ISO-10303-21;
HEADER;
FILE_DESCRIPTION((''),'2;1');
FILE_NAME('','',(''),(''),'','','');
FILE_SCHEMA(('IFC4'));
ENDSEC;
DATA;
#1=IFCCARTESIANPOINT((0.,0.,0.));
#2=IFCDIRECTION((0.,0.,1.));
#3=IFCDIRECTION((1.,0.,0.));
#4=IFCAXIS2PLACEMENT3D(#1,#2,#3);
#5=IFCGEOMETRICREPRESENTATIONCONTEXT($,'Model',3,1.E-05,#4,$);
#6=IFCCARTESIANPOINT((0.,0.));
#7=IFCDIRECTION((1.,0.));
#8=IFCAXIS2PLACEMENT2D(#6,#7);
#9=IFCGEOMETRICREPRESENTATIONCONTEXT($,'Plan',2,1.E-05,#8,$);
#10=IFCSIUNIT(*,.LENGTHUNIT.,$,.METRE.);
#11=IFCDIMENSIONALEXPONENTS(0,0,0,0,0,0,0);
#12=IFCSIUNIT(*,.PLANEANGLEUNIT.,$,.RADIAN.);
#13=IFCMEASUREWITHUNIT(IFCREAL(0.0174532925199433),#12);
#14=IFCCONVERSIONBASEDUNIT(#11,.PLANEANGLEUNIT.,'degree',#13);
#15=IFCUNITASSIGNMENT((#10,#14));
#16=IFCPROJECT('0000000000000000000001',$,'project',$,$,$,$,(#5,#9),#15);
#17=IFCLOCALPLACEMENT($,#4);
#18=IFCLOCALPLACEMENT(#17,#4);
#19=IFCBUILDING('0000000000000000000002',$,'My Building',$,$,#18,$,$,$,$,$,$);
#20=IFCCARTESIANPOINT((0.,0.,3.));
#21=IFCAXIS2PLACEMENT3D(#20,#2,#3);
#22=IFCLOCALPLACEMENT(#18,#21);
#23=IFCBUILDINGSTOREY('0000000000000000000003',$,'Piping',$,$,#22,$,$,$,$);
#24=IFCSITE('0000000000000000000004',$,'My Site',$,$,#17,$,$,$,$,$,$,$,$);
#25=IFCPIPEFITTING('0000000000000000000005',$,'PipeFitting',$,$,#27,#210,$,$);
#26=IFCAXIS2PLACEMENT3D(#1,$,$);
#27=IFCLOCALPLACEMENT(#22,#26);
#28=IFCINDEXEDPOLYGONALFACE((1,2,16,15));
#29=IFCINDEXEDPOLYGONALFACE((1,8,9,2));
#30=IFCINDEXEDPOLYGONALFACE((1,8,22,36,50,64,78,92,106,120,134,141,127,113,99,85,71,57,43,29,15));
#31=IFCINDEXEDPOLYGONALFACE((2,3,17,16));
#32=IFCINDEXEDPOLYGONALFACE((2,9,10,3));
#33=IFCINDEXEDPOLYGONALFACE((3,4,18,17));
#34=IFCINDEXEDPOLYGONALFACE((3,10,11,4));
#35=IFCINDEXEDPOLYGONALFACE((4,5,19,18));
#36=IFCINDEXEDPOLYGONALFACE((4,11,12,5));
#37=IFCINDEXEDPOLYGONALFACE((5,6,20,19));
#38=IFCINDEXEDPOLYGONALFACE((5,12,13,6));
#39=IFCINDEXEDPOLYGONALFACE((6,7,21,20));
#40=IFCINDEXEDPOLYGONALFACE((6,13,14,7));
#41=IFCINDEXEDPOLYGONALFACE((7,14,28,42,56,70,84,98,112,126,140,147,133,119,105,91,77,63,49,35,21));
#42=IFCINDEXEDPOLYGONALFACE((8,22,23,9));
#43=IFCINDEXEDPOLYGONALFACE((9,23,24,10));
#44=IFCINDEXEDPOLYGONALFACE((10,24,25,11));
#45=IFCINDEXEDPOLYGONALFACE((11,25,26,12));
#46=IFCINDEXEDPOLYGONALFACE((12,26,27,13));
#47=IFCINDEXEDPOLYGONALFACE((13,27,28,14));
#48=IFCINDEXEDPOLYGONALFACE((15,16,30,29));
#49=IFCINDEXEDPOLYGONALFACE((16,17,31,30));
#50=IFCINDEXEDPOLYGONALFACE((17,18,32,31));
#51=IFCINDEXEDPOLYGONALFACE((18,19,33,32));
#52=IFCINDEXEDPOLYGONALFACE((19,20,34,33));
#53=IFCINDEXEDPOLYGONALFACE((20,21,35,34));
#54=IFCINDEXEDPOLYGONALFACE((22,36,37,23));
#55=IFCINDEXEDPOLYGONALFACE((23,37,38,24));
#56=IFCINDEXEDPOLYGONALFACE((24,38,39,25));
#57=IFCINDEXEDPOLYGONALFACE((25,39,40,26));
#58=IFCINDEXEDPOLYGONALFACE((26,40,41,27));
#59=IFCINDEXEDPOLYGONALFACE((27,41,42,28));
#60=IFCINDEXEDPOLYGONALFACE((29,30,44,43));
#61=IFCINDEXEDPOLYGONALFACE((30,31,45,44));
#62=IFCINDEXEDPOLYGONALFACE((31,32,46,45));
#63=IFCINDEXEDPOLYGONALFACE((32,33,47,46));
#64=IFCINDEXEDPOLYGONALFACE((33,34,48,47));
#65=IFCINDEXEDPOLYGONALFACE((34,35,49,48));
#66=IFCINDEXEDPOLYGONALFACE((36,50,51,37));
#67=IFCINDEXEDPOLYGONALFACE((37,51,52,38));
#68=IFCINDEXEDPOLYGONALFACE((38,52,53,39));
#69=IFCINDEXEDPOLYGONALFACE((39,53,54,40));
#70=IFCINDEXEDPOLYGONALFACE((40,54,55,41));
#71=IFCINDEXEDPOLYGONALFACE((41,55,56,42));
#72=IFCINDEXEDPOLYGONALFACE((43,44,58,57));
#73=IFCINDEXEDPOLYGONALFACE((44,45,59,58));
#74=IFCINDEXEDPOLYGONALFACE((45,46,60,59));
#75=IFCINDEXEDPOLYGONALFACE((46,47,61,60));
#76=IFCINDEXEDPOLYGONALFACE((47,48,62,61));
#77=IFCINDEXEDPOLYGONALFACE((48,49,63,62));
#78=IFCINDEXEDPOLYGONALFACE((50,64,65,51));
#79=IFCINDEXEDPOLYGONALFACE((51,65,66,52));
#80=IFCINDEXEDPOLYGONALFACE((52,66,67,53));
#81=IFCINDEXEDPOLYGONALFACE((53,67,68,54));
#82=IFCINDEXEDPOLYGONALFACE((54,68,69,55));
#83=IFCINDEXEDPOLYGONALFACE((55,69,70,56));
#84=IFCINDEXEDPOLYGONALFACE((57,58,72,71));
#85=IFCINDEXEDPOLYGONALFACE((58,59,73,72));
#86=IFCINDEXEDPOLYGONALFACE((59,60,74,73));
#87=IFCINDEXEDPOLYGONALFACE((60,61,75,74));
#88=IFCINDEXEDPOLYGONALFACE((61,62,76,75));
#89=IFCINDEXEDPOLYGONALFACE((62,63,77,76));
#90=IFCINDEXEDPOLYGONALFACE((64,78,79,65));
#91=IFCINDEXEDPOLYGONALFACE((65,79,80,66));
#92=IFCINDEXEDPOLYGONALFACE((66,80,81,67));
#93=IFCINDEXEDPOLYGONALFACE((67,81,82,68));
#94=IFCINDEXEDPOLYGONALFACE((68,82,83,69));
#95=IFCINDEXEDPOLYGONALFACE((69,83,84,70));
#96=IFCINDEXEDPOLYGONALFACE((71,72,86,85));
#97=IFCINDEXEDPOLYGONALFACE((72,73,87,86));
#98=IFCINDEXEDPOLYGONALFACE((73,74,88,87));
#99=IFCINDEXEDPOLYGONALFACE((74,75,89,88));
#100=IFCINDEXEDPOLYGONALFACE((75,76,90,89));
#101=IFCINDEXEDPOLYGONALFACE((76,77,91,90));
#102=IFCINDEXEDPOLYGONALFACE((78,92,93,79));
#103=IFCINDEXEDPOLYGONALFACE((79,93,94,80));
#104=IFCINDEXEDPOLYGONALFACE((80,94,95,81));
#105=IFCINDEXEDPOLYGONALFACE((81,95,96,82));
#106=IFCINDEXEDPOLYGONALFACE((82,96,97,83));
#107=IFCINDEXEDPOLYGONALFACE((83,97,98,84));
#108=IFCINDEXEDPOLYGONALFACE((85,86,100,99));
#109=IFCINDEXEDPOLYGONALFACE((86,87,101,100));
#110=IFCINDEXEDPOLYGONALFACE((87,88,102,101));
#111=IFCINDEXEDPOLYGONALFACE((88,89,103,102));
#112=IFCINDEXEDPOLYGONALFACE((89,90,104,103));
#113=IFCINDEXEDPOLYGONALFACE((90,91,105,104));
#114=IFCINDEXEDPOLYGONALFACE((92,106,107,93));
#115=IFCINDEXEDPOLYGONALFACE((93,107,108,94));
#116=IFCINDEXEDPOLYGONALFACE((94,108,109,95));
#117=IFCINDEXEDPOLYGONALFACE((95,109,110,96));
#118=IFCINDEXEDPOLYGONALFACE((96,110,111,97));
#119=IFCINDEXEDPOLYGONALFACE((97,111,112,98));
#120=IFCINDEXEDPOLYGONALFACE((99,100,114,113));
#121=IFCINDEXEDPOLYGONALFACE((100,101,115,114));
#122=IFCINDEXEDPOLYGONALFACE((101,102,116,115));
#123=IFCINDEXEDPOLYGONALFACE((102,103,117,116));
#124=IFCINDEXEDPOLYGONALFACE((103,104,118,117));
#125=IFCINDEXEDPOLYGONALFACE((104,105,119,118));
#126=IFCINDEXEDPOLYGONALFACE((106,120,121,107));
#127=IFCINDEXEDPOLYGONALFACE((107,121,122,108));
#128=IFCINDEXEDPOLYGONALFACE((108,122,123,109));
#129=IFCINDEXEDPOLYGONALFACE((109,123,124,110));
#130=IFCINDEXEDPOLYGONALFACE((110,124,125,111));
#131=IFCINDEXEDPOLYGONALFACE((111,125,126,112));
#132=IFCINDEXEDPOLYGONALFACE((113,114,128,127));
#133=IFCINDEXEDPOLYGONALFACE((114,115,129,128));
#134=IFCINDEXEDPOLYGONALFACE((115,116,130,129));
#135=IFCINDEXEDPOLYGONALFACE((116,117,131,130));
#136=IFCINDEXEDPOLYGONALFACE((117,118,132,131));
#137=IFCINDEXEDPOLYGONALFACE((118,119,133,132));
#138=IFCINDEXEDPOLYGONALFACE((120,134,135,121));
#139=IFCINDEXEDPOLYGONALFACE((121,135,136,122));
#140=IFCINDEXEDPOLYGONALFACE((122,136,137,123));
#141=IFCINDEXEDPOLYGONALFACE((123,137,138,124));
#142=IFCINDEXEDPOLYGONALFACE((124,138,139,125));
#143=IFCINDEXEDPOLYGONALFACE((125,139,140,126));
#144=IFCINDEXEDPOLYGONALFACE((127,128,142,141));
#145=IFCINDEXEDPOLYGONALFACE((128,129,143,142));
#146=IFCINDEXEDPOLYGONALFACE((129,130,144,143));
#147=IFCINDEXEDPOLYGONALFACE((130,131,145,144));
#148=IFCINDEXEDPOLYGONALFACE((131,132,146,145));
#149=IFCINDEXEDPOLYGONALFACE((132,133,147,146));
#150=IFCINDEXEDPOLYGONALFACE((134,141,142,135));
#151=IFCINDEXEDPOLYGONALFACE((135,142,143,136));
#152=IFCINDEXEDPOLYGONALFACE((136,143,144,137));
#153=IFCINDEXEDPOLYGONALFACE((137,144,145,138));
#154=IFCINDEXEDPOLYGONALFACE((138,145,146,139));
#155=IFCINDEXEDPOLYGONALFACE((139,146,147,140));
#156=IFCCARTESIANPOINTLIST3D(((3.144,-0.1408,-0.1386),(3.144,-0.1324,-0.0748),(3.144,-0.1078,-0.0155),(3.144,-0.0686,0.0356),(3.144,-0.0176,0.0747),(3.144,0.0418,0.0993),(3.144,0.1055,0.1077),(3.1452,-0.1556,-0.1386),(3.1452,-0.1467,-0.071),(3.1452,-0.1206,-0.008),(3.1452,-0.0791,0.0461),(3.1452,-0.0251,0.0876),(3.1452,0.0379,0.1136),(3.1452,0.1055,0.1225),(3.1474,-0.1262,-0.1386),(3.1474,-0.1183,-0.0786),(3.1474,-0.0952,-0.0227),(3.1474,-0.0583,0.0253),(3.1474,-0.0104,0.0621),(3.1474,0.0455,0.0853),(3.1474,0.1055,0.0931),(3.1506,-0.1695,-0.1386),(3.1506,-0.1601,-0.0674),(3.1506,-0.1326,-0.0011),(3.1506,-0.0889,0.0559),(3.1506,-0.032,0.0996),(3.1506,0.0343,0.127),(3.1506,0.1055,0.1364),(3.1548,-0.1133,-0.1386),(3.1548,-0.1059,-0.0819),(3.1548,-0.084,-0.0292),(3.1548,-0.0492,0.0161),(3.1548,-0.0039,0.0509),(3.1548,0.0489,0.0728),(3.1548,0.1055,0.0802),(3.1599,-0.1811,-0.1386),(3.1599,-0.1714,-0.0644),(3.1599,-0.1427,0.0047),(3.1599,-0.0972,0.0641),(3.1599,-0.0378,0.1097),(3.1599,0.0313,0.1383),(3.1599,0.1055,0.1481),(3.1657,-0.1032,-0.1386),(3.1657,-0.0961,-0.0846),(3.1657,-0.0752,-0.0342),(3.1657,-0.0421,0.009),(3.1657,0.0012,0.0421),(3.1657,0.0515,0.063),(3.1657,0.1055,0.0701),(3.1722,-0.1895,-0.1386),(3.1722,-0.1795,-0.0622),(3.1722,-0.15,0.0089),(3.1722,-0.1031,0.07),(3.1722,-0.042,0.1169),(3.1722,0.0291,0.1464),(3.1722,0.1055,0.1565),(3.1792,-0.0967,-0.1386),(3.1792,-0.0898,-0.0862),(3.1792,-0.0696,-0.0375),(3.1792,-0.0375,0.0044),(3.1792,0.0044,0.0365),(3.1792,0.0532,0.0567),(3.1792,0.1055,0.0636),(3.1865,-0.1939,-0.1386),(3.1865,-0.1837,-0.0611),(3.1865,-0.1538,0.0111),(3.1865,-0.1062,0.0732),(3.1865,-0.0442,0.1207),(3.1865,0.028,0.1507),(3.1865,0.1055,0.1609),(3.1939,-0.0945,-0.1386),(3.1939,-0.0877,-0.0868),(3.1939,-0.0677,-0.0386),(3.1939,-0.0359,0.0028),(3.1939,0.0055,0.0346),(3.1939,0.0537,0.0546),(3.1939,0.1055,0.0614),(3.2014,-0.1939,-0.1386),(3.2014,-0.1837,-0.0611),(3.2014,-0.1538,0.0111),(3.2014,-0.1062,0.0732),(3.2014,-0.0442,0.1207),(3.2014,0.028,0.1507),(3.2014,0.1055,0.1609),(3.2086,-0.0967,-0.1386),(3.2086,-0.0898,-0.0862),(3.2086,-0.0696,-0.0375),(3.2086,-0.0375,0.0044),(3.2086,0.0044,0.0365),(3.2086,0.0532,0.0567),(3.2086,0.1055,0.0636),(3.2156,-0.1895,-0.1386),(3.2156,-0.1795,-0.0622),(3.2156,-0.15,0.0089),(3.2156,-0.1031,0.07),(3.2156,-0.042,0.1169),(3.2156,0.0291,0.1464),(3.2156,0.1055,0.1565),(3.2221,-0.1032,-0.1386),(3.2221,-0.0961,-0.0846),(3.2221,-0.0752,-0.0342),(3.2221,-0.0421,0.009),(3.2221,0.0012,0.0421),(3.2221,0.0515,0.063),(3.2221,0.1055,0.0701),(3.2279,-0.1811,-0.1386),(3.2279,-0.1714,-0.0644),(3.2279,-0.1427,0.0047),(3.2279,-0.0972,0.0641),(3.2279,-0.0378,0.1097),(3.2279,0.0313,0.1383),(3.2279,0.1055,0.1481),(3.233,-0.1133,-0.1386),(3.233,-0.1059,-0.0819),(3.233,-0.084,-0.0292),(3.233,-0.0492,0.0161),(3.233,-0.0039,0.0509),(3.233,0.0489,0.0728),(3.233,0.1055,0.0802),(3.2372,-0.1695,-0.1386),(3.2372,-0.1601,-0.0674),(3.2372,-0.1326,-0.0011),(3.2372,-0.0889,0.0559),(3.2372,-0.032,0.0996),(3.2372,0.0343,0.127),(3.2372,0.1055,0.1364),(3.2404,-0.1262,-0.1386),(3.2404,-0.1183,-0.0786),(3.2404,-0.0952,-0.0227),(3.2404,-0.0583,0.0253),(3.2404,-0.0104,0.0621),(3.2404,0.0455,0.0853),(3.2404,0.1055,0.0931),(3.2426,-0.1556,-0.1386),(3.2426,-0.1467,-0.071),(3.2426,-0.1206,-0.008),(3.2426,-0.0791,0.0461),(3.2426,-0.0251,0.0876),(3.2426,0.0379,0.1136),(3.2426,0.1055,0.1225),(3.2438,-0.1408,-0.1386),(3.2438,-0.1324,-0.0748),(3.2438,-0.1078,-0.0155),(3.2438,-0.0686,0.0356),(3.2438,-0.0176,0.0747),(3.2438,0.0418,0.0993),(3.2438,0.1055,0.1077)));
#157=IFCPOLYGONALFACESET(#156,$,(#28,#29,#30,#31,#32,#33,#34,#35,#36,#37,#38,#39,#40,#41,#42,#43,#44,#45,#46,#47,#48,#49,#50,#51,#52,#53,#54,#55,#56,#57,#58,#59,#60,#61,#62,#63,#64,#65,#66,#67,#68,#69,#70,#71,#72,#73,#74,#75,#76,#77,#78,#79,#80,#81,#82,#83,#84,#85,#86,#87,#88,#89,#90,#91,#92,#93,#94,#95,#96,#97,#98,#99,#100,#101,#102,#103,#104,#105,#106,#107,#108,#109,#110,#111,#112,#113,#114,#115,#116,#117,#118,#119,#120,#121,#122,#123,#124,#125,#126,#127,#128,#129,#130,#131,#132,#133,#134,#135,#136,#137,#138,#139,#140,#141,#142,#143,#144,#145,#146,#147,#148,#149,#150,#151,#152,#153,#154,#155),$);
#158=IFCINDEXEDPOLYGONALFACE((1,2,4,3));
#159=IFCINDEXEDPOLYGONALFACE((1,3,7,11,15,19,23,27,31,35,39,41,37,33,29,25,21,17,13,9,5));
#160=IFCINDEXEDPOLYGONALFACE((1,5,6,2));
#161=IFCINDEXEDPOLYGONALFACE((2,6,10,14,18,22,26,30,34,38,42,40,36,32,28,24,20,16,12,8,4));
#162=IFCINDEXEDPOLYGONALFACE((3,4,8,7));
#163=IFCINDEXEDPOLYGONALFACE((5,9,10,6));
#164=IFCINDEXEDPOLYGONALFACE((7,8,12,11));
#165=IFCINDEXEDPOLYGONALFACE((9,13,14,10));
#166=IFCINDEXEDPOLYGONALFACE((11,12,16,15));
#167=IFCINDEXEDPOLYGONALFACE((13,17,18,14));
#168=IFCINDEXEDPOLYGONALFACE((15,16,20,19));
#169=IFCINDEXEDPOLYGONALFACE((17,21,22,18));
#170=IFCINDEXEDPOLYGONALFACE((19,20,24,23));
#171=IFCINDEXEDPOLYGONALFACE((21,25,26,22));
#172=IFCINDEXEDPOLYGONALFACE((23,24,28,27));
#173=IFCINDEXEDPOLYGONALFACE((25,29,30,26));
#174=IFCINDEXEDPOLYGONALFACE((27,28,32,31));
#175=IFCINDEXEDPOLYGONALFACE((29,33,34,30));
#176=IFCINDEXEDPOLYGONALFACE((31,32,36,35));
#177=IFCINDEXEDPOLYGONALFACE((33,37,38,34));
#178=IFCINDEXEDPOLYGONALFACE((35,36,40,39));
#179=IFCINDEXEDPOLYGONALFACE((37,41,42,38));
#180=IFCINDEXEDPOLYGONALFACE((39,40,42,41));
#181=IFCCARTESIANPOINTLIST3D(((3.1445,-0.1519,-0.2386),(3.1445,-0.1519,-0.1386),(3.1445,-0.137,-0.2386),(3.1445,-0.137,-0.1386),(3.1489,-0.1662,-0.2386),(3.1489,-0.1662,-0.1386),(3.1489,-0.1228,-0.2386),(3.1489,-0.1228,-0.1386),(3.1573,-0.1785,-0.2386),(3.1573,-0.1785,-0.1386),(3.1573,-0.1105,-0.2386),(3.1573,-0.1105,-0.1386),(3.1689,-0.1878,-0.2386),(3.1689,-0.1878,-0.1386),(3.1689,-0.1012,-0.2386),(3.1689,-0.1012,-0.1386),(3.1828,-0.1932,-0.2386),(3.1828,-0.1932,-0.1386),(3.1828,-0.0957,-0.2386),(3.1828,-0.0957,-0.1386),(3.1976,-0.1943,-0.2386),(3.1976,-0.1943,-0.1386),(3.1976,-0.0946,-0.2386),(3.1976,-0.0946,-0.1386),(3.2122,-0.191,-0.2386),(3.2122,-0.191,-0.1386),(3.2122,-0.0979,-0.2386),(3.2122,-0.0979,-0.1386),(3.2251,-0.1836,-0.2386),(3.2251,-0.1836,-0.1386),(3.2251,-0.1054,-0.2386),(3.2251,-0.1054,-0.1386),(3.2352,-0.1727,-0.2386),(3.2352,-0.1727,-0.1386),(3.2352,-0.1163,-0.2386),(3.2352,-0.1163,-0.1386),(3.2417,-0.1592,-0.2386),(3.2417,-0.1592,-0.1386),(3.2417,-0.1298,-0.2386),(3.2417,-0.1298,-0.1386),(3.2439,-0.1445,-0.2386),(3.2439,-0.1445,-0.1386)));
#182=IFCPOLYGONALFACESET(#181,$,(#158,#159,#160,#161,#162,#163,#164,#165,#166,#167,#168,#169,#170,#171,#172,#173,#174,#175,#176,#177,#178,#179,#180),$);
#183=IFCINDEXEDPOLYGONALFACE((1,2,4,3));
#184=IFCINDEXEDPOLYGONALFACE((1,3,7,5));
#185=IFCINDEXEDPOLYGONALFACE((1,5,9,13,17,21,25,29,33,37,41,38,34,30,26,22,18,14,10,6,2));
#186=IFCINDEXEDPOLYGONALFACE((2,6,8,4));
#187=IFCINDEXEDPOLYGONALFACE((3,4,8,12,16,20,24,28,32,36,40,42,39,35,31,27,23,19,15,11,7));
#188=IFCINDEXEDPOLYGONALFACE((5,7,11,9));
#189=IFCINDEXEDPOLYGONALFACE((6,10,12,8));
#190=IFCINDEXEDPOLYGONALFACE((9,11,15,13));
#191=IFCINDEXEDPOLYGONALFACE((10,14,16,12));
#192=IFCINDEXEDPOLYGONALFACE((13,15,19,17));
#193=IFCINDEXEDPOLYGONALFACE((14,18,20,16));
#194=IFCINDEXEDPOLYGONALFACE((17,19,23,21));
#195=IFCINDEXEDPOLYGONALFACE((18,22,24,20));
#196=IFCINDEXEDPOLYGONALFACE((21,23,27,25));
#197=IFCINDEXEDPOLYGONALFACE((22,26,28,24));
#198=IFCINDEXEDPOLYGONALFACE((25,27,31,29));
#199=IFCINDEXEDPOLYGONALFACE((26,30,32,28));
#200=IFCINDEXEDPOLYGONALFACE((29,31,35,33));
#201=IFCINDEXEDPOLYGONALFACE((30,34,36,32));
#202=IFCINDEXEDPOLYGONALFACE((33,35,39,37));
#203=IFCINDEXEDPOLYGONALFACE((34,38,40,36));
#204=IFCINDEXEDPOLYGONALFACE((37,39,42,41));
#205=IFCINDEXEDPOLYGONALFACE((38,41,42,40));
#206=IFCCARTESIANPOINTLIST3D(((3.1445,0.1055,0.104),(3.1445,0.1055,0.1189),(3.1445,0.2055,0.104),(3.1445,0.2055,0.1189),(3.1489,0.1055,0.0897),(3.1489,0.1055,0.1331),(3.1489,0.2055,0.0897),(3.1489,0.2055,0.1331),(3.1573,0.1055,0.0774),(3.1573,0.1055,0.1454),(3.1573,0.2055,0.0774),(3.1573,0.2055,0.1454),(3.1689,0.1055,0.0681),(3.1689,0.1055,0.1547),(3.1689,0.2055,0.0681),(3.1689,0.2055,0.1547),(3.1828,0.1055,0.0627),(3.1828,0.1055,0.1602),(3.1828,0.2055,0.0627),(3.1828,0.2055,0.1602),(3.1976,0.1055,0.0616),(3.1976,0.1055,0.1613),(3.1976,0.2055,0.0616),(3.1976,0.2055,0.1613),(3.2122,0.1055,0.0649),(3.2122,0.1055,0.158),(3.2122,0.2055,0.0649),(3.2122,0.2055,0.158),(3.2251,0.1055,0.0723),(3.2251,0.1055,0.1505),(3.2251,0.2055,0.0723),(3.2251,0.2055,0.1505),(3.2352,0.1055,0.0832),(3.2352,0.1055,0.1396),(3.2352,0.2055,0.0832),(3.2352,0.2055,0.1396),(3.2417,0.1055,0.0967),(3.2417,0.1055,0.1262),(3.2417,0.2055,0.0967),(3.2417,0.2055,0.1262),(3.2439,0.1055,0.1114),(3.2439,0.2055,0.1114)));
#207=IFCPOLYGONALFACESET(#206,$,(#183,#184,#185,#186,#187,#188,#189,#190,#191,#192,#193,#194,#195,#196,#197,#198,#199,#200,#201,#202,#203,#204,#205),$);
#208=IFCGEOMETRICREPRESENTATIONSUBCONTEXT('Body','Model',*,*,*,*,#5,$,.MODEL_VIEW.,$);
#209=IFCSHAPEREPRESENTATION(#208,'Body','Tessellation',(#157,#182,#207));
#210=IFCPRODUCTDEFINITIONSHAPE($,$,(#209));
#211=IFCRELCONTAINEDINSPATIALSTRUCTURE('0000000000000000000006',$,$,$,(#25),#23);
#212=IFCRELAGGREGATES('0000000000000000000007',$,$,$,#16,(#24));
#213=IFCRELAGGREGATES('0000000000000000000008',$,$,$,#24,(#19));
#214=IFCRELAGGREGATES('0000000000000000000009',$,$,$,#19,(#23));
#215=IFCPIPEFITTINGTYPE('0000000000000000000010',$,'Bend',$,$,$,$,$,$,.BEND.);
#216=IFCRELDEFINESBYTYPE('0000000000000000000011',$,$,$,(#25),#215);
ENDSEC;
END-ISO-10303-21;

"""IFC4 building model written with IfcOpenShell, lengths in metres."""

from ifc_helpers import new_model, entity, si_unit, converted_unit, frame, origin_with_axes, origin_2d_with_axis, place, context, subcontext, project, spatial, circle, extrude, source, transform, mapped, type_object, type_shapes, element, save


model = new_model("IFC4")

# Units and contexts
model_context = context("Model", 3, precision=1e-05, world=origin_with_axes())
plan_context = context("Plan", 2, precision=1e-05, world=origin_2d_with_axis())
body_context = subcontext(model_context, "Body", "Model", "MODEL_VIEW")
ifc_project = project(units=[si_unit("LENGTHUNIT", "METRE"), converted_unit("PLANEANGLEUNIT", "degree", entity("IfcReal", 0.0174532925199433), si_unit("PLANEANGLEUNIT", "RADIAN"), dimensions=[0, 0, 0, 0, 0, 0, 0])], contexts=[model_context, plan_context])

# Site, building, storey
site_placement = place(None, origin_with_axes())
site = spatial("IfcSite", under=ifc_project, at=site_placement, Name="My Site")
building_placement = place(site_placement, origin_with_axes())
building = spatial("IfcBuilding", under=site, at=building_placement, Name="My Building")
storey_placement = place(building_placement, frame((0.0, 0.0, 3.0), z_axis=(0.0, 0.0, 1.0), x_axis=(1.0, 0.0, 0.0)))
storey = spatial("IfcBuildingStorey", under=building, at=storey_placement, Name="Piping")

# Pipe fitting
pipe_fitting_type_1 = type_object("IfcPipeFittingType", Name="Bend", PredefinedType="BEND")
shared_shape = source(origin_with_axes(), body_context, "Body", "SolidModel", [
    entity("IfcSweptDiskSolid", entity("IfcIndexedPolyCurve", entity("IfcCartesianPointList3D", [[0.0, 0.0, -0.1], [0.0, -0.0732, -0.2768], [0.0, -0.25, -0.35]]), [entity("IfcArcIndex", [1, 2, 3])]), 0.05),
    extrude(circle(Radius=0.05), origin_with_axes(), (0.0, 0.0, -1.0), 0.1),
    extrude(circle(Radius=0.05), frame((0.0, -0.25, -0.35), z_axis=(0.0, -1.0, 0.0), x_axis=(1.0, 0.0, 0.0)), (0.0, 0.0, 1.0), 0.1),
])
type_shapes(pipe_fitting_type_1, [shared_shape])
for number, where, z_axis, x_axis, name in (
    (1, (3.1939, -0.1445, -0.2386), (0.0, 0.0, -1.0), (1.0, 0.0, 0.0), "PipeFitting"),
):
    element("IfcPipeFitting", number, at=place(storey_placement, frame(where, z_axis=z_axis, x_axis=x_axis)), inside=storey, type_object=pipe_fitting_type_1, Name=name, context=body_context, shape_type="MappedRepresentation", body=[
        mapped(shared_shape, transform((0.0, 0.0, 0.0), x_axis=(1.0, 0.0, 0.0), y_axis=(0.0, 1.0, 0.0), z_axis=(0.0, 0.0, 1.0), scale=1.0)),
    ])

save(model, "model.ifc")
